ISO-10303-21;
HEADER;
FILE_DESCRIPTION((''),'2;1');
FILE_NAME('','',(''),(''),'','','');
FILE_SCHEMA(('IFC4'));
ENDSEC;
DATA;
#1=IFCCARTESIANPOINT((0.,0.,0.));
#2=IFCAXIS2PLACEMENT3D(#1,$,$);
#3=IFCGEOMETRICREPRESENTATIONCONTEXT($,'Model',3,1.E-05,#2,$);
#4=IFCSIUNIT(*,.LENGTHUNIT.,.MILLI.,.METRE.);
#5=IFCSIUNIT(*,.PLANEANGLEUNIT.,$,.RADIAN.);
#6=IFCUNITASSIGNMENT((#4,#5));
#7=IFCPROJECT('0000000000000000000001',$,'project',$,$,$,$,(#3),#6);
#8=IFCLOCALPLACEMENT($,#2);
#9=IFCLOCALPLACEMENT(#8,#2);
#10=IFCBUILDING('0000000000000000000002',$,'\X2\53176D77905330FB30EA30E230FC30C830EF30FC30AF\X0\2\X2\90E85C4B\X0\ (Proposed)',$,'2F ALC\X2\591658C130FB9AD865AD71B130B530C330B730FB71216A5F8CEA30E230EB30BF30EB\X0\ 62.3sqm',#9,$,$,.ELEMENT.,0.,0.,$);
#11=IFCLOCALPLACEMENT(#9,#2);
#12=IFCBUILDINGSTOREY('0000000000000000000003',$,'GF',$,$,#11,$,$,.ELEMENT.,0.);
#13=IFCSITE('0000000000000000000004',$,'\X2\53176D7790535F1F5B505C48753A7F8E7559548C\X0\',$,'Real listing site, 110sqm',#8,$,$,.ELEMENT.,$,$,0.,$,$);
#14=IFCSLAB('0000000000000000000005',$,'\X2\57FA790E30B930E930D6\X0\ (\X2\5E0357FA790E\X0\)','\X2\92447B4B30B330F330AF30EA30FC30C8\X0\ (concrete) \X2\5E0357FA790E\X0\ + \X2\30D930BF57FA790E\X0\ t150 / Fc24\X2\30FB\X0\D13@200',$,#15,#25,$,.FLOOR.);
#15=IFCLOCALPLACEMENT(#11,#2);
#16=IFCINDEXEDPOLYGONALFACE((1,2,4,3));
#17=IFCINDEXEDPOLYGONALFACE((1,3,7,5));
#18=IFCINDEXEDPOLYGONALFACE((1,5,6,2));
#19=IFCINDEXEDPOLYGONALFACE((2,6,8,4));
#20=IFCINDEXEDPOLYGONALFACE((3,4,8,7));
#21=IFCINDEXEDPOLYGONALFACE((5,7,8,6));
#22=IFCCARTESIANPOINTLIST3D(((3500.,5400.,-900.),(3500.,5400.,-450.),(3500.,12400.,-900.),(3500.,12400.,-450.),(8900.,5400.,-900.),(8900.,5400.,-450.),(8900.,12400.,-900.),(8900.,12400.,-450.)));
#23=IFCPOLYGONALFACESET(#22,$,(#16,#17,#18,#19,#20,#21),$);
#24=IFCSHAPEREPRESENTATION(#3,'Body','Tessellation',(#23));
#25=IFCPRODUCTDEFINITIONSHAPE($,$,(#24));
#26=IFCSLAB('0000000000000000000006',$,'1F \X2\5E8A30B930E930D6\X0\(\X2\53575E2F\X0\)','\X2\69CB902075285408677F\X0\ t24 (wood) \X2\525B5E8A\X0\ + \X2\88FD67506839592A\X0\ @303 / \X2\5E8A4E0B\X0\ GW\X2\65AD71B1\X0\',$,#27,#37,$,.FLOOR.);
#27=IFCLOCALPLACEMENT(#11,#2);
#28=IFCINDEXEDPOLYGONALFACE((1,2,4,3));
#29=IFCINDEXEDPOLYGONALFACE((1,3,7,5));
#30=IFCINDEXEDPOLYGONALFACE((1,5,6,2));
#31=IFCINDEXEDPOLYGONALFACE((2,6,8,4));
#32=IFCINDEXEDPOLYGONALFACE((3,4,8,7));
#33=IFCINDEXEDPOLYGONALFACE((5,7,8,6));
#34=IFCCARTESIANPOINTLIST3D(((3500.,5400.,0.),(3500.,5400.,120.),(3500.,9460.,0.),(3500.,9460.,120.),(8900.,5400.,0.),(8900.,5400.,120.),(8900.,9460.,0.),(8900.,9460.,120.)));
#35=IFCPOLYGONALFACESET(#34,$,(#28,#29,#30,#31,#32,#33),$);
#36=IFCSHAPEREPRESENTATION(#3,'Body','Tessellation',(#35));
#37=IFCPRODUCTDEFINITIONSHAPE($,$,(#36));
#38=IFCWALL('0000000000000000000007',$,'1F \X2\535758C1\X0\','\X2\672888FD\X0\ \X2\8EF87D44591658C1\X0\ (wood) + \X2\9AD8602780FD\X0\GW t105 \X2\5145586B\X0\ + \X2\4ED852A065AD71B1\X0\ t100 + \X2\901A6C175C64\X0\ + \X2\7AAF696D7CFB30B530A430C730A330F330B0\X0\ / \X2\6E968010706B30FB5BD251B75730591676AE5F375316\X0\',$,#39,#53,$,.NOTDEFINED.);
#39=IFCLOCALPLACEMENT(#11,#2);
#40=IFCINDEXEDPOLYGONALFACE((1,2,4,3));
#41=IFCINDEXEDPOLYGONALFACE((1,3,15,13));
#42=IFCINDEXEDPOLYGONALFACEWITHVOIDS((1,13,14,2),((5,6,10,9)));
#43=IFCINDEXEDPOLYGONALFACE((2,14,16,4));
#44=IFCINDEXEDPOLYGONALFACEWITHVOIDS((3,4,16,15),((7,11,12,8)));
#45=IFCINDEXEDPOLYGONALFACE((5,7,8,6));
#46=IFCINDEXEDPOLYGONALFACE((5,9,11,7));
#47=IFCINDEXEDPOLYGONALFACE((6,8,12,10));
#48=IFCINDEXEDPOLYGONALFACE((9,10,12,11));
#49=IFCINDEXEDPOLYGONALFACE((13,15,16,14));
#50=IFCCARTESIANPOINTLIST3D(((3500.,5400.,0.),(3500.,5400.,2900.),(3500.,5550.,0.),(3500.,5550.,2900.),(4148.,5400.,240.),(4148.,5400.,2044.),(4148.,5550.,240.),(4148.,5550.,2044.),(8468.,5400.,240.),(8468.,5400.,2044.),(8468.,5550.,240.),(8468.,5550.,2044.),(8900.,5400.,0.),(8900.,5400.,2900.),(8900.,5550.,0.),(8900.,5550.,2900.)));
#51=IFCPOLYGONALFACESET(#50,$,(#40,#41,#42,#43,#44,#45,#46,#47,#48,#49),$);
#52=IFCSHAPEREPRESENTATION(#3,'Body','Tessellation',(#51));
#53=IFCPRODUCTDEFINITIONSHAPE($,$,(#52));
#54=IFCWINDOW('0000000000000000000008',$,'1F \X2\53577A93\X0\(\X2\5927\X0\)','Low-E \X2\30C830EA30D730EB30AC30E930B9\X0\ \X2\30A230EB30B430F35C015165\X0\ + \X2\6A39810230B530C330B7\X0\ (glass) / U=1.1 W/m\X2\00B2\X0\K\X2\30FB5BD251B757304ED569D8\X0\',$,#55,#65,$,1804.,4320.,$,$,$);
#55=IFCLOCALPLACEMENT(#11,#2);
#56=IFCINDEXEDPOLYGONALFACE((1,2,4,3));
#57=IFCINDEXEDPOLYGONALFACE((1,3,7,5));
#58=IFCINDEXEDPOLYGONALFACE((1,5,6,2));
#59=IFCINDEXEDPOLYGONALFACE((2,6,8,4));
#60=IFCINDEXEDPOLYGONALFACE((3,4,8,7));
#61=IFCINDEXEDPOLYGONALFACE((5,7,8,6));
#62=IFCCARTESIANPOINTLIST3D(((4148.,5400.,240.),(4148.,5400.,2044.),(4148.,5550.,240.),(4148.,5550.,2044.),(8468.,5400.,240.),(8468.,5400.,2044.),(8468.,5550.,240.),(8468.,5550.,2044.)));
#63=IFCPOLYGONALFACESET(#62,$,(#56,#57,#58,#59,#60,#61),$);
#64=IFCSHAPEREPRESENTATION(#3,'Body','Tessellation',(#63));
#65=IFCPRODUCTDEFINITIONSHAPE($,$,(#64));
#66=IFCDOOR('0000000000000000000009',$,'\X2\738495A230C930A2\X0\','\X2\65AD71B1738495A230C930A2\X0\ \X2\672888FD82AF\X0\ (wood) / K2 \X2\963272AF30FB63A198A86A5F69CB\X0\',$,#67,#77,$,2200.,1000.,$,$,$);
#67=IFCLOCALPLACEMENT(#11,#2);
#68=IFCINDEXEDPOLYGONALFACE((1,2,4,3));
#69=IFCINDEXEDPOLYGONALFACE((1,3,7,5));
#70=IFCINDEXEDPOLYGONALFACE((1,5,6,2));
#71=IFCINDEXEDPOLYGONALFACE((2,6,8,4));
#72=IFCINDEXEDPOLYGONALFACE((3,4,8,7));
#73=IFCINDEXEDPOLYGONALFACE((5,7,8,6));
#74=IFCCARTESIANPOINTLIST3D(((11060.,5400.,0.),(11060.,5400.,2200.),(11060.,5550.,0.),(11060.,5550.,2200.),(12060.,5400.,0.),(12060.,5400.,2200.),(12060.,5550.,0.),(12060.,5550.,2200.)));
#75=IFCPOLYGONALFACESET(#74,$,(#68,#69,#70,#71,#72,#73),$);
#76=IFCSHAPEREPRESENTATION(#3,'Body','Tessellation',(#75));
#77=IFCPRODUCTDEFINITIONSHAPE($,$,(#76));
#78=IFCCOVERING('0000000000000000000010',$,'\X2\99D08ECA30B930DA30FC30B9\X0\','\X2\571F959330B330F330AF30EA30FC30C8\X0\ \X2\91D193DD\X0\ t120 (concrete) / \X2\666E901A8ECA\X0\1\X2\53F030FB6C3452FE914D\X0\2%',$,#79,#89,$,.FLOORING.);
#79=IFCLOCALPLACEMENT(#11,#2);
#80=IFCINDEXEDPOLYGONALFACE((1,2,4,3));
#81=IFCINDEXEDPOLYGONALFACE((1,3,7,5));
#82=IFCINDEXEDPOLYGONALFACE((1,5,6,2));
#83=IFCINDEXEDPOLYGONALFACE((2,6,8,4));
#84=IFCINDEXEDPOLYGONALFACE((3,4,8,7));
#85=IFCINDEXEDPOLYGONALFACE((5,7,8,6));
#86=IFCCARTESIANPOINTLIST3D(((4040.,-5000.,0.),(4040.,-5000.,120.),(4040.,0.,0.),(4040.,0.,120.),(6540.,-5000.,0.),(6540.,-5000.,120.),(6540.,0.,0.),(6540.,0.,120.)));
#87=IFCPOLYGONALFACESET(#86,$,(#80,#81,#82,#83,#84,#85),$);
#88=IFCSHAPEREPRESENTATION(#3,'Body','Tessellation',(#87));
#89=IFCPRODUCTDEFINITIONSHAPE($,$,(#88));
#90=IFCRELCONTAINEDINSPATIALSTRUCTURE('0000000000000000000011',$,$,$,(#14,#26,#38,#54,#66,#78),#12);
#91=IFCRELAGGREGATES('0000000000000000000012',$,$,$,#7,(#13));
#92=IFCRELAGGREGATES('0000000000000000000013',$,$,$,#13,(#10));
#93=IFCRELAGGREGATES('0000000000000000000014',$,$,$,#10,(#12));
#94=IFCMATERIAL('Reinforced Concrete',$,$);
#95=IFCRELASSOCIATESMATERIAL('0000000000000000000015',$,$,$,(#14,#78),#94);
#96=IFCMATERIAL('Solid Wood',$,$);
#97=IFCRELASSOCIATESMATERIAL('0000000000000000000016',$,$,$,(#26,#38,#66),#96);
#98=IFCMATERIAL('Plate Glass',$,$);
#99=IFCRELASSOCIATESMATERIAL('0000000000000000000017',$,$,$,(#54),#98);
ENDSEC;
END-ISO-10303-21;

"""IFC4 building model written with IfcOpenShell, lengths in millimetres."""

from ifc_helpers import new_model, si_unit, frame, frame_2d, origin, place, context, project, spatial, rectangle, extrude, material, element, fill, save


model = new_model("IFC4")

# Units and contexts
model_context = context("Model", 3, precision=1e-05, world=origin())
ifc_project = project(units=[si_unit("LENGTHUNIT", "METRE", prefix="MILLI"), si_unit("PLANEANGLEUNIT", "RADIAN")], contexts=[model_context])

# Site, building, storey
site_placement = place(None, origin())
site = spatial("IfcSite", under=ifc_project, at=site_placement, Name="北海道弟子屈町美留和", ObjectType="Real listing site, 110sqm", CompositionType="ELEMENT", RefElevation=0.0)
building_placement = place(site_placement, origin())
building = spatial("IfcBuilding", under=site, at=building_placement, Name="北海道・リモートワーク2部屋 (Proposed)", ObjectType="2F ALC外壁・高断熱サッシ・無機質モルタル 62.3sqm", CompositionType="ELEMENT", ElevationOfRefHeight=0.0, ElevationOfTerrain=0.0)
storey_placement = place(building_placement, origin())
storey = spatial("IfcBuildingStorey", under=building, at=storey_placement, Name="GF", CompositionType="ELEMENT", Elevation=0.0)

# Shared definitions
ifc_material_1 = material(Name="Solid Wood")

# Slabs
ifc_material_2 = material(Name="Reinforced Concrete")
slab_1_placement = place(storey_placement, frame((1750.0, 2700.0, -450.0)))
element("IfcSlab", 1, at=slab_1_placement, inside=storey, material=ifc_material_2, Name="基礎スラブ (布基礎)", Description="鉄筋コンクリート (concrete) 布基礎 + ベタ基礎 t150 / Fc24・D13@200", PredefinedType="FLOOR", context=model_context, shape_type="SweptSolid", body=[
    extrude(rectangle(XDim=5400.0, YDim=7000.0, at=frame_2d((2700.0, 3500.0))), frame((1750.0, 2700.0, -450.0)), (0.0, 0.0, 1.0), 450.0),
])
slab_2_placement = place(storey_placement, frame((1750.0, 2700.0, 0.0)))
element("IfcSlab", 2, at=slab_2_placement, inside=storey, material=ifc_material_1, Name="1F 床スラブ(南帯)", Description="構造用合板 t24 (wood) 剛床 + 製材根太 @303 / 床下 GW断熱", PredefinedType="FLOOR", context=model_context, shape_type="SweptSolid", body=[
    extrude(rectangle(XDim=5400.0, YDim=4060.0, at=frame_2d((2700.0, 2030.0))), frame((1750.0, 2700.0, 0.0)), (0.0, 0.0, 1.0), 120.0),
])

# Wall, openings, window, door
wall_1_placement = place(storey_placement, frame((1750.0, 2700.0, 0.0)))
wall_1 = element("IfcWall", 3, at=wall_1_placement, inside=storey, material=ifc_material_1, Name="1F 南壁", Description="木製 軸組外壁 (wood) + 高性能GW t105 充填 + 付加断熱 t100 + 通気層 + 窯業系サイディング / 準耐火・寒冷地外皮強化", PredefinedType="NOTDEFINED", context=model_context, shape_type="SweptSolid", body=[
    extrude(rectangle(XDim=5400.0, YDim=150.0, at=frame_2d((2700.0, 75.0))), frame((1750.0, 2700.0, 0.0)), (0.0, 0.0, 1.0), 2900.0),
])
opening_1_placement = place(storey_placement, frame((2074.0, 2700.0, 120.0)))
opening_1 = element("IfcOpeningElement", 4, at=opening_1_placement, cuts=wall_1, PredefinedType="NOTDEFINED", context=model_context, shape_type="SweptSolid", body=[
    extrude(rectangle(XDim=4320.0, YDim=150.0, at=frame_2d((2160.0, 75.0))), frame((2074.0, 2700.0, 120.0)), (0.0, 0.0, 1.0), 1804.0),
])
opening_2_placement = place(storey_placement, frame((5530.0, 2700.0, 0.0)))
opening_2 = element("IfcOpeningElement", 5, at=opening_2_placement, cuts=wall_1, PredefinedType="NOTDEFINED", context=model_context, shape_type="SweptSolid", body=[
    extrude(rectangle(XDim=1000.0, YDim=150.0, at=frame_2d((500.0, 75.0))), frame((5530.0, 2700.0, 0.0)), (0.0, 0.0, 1.0), 2200.0),
])
ifc_material_3 = material(Name="Plate Glass")
window_1_placement = place(storey_placement, frame((2074.0, 2700.0, 120.0)))
window_1 = element("IfcWindow", 6, at=window_1_placement, inside=storey, material=ifc_material_3, Name="1F 南窓(大)", Description="Low-E トリプルガラス アルゴン封入 + 樹脂サッシ (glass) / U=1.1 W/m²K・寒冷地仕様", OverallHeight=1804.0, OverallWidth=4320.0, context=model_context, shape_type="SweptSolid", body=[
    extrude(rectangle(XDim=4320.0, YDim=150.0, at=frame_2d((2160.0, 75.0))), frame((2074.0, 2700.0, 120.0)), (0.0, 0.0, 1.0), 1804.0),
])
fill(opening_1, window_1)
door_1_placement = place(storey_placement, frame((5530.0, 2700.0, 0.0)))
door_1 = element("IfcDoor", 7, at=door_1_placement, inside=storey, material=ifc_material_1, Name="玄関ドア", Description="断熱玄関ドア 木製芯 (wood) / K2 防犯・採風機構", OverallHeight=2200.0, OverallWidth=1000.0, context=model_context, shape_type="SweptSolid", body=[
    extrude(rectangle(XDim=1000.0, YDim=150.0, at=frame_2d((500.0, 75.0))), frame((5530.0, 2700.0, 0.0)), (0.0, 0.0, 1.0), 2200.0),
])
fill(opening_2, door_1)

# Covering
covering_1_placement = place(storey_placement, frame((2020.0, -2500.0, 0.0)))
element("IfcCovering", 8, at=covering_1_placement, inside=storey, material=ifc_material_2, Name="駐車スペース", Description="土間コンクリート 金鏝 t120 (concrete) / 普通車1台・水勾配2%", PredefinedType="FLOORING", context=model_context, shape_type="SweptSolid", body=[
    extrude(rectangle(XDim=2500.0, YDim=5000.0, at=frame_2d((1250.0, 2500.0))), frame((2020.0, -2500.0, 0.0)), (0.0, 0.0, 1.0), 120.0),
])

save(model, "model.ifc")
